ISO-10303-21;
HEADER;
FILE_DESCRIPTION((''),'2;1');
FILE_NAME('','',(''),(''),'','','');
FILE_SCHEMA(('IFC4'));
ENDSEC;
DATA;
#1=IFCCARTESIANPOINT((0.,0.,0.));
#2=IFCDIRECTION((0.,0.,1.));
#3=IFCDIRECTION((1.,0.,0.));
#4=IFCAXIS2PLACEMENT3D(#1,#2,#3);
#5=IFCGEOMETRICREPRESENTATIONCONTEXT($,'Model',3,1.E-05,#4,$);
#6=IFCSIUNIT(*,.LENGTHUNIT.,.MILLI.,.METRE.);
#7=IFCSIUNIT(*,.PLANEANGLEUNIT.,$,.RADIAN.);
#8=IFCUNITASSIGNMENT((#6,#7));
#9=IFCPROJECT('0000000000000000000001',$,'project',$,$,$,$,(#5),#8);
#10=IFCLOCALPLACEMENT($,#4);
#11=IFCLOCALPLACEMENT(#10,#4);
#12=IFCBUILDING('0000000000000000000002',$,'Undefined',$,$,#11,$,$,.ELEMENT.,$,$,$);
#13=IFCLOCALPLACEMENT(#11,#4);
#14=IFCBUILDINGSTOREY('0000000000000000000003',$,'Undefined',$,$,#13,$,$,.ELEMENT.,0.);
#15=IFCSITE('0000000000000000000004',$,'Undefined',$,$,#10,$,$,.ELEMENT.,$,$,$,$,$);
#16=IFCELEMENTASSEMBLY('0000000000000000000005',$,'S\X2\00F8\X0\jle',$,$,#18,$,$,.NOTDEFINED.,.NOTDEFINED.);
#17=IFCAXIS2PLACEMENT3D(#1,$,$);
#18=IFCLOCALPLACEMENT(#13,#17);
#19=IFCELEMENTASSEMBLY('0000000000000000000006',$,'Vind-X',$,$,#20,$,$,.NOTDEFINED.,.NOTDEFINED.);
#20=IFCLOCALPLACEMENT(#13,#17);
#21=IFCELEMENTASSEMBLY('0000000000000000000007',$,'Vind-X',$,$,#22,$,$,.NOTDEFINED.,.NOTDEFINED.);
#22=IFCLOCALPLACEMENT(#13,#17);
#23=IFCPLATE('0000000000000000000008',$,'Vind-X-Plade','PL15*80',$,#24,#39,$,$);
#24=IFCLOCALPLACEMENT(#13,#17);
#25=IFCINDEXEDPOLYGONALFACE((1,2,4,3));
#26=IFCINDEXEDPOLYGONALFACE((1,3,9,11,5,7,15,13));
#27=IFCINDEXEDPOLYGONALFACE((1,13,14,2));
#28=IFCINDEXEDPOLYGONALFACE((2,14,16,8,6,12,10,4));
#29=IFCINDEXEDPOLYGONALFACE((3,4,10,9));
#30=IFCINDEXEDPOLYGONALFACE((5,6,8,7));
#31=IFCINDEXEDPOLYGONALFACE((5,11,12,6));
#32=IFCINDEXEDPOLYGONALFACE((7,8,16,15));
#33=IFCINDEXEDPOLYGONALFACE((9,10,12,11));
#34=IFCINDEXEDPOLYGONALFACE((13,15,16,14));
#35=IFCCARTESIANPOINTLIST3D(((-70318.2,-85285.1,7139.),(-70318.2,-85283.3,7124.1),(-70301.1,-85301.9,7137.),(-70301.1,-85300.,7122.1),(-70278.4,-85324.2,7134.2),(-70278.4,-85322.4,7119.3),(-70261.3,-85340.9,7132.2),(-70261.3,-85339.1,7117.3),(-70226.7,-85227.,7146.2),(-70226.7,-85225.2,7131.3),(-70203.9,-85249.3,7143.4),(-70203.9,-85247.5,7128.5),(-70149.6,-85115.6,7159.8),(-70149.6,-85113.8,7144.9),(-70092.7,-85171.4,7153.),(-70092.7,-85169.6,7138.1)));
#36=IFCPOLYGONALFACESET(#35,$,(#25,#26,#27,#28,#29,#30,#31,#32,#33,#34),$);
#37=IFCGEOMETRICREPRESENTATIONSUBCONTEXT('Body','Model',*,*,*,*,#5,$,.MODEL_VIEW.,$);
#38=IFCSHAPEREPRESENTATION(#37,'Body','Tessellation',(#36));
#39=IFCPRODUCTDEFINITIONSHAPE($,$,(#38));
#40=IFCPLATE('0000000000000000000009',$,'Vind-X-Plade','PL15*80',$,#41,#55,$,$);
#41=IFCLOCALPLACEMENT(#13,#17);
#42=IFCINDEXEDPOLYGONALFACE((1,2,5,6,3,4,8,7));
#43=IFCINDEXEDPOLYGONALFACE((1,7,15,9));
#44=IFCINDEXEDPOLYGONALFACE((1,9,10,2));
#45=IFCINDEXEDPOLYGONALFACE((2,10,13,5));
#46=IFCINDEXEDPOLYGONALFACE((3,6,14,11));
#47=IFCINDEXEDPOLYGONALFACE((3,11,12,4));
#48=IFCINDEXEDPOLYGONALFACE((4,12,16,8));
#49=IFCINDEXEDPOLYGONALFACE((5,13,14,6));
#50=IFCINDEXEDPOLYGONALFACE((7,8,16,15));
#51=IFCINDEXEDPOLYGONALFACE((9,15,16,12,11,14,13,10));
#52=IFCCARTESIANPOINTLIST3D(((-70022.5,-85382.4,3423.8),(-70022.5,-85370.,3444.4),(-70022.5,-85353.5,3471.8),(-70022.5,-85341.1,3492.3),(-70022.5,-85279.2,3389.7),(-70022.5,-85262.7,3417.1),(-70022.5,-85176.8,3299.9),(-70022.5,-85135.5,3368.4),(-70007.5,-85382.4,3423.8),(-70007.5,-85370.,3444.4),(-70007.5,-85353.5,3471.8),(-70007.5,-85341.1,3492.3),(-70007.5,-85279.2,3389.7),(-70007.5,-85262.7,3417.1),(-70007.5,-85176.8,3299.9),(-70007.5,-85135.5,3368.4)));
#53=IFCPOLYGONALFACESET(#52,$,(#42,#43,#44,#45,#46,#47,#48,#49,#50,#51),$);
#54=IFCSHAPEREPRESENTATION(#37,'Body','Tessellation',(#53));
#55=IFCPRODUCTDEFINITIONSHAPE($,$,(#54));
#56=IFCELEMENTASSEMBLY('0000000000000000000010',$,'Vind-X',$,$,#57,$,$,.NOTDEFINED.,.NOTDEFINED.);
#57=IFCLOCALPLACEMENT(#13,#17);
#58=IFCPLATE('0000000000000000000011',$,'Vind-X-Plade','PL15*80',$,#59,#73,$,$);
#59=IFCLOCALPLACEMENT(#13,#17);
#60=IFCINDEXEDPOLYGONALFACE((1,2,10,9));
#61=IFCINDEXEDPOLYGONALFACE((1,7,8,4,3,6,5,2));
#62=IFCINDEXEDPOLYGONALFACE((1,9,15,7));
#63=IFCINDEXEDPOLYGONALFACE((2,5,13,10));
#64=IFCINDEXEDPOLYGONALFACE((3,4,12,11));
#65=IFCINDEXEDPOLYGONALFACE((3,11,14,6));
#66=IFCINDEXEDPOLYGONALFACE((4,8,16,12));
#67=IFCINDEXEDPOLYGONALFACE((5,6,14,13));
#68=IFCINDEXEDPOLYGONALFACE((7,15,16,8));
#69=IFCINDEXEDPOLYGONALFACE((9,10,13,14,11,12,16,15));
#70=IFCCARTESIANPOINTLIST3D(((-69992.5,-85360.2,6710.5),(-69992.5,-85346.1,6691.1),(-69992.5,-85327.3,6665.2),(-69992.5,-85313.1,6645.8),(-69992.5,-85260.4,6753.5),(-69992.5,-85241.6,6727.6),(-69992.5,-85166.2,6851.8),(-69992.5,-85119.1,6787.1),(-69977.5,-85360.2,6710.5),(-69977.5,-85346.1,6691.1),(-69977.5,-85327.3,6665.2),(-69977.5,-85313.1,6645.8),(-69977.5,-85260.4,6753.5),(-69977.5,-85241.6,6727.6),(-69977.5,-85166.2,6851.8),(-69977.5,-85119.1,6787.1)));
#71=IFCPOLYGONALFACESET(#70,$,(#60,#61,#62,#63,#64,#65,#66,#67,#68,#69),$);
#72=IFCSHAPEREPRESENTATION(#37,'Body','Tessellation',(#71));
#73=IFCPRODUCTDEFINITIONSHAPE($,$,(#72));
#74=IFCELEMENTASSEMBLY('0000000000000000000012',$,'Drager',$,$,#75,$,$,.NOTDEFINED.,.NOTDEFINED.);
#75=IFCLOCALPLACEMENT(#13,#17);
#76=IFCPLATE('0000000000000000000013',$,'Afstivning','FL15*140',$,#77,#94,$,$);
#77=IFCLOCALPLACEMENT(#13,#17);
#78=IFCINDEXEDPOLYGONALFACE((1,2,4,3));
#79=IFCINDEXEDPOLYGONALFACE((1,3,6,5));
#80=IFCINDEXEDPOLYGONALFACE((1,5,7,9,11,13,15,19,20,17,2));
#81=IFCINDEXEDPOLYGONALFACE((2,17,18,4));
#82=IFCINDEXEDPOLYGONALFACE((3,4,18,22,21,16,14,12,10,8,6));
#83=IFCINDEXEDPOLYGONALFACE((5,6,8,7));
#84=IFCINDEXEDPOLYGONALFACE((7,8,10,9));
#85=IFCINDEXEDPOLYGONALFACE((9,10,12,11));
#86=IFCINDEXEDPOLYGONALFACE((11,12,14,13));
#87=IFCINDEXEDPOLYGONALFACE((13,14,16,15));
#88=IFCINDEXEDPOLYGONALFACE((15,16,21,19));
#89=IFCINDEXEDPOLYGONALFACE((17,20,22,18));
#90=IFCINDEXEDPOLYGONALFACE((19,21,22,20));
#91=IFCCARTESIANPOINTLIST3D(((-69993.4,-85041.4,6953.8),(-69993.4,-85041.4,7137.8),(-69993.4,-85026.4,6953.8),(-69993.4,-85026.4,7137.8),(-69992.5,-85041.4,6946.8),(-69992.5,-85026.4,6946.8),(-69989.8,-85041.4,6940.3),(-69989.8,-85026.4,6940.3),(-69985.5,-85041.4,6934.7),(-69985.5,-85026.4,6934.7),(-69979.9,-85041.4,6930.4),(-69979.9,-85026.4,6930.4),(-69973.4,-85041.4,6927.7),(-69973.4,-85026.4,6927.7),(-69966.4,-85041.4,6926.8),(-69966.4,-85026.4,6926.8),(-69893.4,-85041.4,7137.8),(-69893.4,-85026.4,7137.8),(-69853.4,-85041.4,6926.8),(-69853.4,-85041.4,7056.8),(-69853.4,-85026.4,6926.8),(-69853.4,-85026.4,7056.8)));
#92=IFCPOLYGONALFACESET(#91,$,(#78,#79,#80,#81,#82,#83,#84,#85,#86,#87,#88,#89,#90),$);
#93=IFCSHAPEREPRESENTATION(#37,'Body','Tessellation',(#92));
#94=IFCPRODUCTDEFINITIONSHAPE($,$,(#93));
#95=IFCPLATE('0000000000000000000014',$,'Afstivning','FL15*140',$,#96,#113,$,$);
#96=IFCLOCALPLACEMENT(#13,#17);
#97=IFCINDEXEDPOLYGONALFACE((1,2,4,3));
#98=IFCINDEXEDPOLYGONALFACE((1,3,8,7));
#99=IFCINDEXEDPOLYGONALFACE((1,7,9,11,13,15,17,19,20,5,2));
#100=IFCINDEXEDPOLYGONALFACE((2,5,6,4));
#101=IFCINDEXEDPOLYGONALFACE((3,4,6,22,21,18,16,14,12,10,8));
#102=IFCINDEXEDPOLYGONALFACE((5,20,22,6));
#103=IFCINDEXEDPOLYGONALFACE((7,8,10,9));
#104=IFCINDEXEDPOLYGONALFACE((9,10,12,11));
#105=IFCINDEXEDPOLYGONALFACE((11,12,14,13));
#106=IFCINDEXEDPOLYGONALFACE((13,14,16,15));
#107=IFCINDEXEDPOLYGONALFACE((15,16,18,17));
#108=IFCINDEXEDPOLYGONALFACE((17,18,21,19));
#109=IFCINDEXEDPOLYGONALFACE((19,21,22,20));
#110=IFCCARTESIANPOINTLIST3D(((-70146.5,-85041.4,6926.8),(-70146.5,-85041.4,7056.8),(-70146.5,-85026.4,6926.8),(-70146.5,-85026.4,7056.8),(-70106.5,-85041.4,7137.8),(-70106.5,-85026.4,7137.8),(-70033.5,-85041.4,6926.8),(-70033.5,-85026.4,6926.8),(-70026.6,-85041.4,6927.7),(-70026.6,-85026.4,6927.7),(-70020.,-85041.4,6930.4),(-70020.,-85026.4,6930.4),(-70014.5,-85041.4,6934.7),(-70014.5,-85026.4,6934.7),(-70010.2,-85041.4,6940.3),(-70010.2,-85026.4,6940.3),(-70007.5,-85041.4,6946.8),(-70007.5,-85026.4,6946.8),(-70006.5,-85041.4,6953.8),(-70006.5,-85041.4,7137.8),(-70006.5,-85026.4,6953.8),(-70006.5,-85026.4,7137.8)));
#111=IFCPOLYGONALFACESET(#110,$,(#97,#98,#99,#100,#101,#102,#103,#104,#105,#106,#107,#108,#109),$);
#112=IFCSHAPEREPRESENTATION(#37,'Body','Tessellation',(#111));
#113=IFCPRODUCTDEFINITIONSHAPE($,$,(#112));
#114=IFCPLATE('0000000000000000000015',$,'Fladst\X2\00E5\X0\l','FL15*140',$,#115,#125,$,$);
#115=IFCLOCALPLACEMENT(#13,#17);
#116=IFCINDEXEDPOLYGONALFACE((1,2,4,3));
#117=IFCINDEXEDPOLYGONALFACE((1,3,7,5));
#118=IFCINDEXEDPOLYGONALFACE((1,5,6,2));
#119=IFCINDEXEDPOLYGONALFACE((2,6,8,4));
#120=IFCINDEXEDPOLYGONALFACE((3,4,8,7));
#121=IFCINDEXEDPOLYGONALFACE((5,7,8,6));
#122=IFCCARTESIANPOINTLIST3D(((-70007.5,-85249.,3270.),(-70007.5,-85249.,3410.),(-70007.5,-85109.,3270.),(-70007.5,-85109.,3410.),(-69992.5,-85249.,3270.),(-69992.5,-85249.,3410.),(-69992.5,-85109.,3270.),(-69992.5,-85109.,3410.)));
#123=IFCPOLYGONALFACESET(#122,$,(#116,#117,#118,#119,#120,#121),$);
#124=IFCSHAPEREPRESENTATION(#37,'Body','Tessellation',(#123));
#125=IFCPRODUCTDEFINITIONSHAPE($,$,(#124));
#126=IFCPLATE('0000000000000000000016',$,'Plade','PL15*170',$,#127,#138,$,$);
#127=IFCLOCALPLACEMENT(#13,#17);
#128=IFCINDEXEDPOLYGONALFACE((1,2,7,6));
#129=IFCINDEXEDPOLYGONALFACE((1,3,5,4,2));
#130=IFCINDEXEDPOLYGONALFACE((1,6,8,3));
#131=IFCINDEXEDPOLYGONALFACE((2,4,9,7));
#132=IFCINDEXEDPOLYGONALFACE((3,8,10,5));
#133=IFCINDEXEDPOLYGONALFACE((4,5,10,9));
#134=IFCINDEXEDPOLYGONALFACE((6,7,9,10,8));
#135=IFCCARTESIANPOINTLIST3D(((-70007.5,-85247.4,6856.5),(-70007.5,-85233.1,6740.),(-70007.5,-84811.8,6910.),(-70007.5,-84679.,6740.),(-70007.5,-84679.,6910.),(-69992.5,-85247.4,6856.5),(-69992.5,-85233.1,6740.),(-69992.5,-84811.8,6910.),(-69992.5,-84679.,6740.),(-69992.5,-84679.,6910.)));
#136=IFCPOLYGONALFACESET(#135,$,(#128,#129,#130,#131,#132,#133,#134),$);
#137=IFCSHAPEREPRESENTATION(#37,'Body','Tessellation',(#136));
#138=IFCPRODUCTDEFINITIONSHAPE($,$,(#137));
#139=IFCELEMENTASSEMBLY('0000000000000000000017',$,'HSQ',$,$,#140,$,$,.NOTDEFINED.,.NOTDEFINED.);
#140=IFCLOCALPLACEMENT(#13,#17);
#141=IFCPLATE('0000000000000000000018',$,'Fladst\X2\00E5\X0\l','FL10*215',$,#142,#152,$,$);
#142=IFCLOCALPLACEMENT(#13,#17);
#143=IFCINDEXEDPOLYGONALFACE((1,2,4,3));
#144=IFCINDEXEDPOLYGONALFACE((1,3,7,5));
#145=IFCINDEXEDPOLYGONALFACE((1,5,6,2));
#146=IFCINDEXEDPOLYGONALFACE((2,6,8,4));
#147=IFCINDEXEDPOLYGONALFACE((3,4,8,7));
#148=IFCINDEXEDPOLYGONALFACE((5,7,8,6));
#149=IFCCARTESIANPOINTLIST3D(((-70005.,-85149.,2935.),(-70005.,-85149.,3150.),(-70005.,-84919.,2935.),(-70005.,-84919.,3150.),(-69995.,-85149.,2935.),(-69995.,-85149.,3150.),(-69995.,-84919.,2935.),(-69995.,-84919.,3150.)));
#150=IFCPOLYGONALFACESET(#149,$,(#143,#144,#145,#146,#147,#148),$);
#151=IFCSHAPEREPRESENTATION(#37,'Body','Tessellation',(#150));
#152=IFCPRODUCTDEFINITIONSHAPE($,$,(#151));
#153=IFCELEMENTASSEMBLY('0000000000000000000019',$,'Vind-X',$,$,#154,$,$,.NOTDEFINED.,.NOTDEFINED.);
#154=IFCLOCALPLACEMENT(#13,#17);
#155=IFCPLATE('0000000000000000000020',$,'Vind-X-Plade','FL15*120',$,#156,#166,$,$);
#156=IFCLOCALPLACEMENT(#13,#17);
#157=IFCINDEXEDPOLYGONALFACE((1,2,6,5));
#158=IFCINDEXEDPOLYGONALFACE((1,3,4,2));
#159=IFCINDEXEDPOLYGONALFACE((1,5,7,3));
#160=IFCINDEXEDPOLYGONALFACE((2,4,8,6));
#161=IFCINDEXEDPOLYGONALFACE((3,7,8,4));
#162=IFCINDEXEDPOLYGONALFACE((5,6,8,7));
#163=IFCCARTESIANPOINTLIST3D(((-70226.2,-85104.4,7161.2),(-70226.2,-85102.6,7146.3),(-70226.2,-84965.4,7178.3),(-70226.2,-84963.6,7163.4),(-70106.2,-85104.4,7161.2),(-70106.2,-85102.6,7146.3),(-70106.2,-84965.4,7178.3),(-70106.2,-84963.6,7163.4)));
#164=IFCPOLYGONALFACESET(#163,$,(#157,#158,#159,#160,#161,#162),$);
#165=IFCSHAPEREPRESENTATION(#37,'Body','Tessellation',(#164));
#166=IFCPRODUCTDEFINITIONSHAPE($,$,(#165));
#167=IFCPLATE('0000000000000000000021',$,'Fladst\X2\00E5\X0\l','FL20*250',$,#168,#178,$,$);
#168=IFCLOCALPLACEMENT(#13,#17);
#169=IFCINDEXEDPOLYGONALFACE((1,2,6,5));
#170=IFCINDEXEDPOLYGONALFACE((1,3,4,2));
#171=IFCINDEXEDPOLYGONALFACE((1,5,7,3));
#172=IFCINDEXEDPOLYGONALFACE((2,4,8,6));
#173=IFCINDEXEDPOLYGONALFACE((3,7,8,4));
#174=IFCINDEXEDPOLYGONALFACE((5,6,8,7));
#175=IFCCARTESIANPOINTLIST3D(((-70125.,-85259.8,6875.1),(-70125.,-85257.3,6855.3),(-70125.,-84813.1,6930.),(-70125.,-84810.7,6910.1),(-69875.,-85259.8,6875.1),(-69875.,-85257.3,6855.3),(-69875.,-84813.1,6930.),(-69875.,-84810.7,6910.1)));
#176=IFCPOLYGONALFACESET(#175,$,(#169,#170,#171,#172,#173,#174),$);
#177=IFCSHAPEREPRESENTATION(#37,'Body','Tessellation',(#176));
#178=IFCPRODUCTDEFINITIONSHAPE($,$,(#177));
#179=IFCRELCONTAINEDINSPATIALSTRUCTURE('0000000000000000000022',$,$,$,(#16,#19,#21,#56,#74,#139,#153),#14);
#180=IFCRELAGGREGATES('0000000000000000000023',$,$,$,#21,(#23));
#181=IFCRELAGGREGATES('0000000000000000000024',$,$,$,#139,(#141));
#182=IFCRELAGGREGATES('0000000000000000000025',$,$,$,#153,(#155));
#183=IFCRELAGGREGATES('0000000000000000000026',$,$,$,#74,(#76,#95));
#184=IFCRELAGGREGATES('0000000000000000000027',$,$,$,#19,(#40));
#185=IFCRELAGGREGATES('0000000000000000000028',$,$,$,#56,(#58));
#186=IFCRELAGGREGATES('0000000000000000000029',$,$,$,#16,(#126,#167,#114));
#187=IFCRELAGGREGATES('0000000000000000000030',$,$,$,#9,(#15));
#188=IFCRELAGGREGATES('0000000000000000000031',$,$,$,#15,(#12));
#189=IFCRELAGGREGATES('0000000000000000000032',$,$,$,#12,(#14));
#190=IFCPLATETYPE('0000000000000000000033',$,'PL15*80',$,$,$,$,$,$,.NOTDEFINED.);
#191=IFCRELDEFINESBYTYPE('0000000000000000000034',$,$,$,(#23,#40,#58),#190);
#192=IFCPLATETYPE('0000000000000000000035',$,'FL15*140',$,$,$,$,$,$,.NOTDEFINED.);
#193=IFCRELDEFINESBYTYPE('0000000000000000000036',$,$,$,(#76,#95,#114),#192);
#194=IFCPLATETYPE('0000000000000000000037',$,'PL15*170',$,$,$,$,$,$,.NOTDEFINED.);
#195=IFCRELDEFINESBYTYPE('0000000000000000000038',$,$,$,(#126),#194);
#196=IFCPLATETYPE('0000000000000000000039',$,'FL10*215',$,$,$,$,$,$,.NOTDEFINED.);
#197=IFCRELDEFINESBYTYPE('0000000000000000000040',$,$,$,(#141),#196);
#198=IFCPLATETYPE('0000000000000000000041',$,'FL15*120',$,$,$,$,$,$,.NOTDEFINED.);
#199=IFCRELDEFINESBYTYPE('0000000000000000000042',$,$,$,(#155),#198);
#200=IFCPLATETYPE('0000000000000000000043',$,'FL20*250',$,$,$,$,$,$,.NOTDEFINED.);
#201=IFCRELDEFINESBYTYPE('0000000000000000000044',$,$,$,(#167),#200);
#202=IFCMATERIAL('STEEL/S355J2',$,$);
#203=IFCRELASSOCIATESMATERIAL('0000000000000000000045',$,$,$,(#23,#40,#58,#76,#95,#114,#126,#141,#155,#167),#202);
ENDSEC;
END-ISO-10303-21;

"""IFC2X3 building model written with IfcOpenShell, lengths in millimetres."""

from ifc_helpers import new_model, si_unit, frame, frame_2d, origin_with_axes, place, context, subcontext, project, spatial, polyline, circle_curve, parameter, trimmed, segment, composite_curve, outline, extrude, boolean, material, type_object, element, aggregate, save


model = new_model("IFC2X3")

# Units and contexts
model_context = context("Model", 3, precision=1e-05, world=origin_with_axes())
body_context = subcontext(model_context, "Body", "Model", "MODEL_VIEW")
ifc_project = project(units=[si_unit("LENGTHUNIT", "METRE", prefix="MILLI"), si_unit("PLANEANGLEUNIT", "RADIAN")], contexts=[model_context])

# Site, building, storey
site_placement = place(None, origin_with_axes())
site = spatial("IfcSite", under=ifc_project, at=site_placement, Name="Undefined", CompositionType="ELEMENT")
building_placement = place(site_placement, origin_with_axes())
building = spatial("IfcBuilding", under=site, at=building_placement, Name="Undefined", CompositionType="ELEMENT")
storey_placement = place(building_placement, origin_with_axes())
storey = spatial("IfcBuildingStorey", under=building, at=storey_placement, Name="Undefined", CompositionType="ELEMENT", Elevation=0.0)

# Element assembly
assembly_1_placement = place(storey_placement, origin_with_axes())
assembly_1 = element("IfcElementAssembly", 1, at=assembly_1_placement, inside=storey, Name="Søjle", AssemblyPlace="NOTDEFINED", PredefinedType="NOTDEFINED")

# Element assembly
assembly_2_placement = place(storey_placement, origin_with_axes())
assembly_2 = element("IfcElementAssembly", 2, at=assembly_2_placement, inside=storey, Name="Vind-X", AssemblyPlace="NOTDEFINED", PredefinedType="NOTDEFINED")
ifc_material_1 = material(Name="STEEL/S355J2")

# Element assembly, plate
assembly_3_placement = place(storey_placement, origin_with_axes())
assembly_3 = element("IfcElementAssembly", 3, at=assembly_3_placement, inside=storey, Name="Vind-X", AssemblyPlace="NOTDEFINED", PredefinedType="NOTDEFINED")
plate_type_1 = type_object("IfcPlateType", Name="PL15*80", PredefinedType="NOTDEFINED")
plate_1_placement = place(assembly_3_placement, frame((-70092.7, -85170.5, 7145.5), z_axis=(0.0, -0.121869, 0.992546), x_axis=(-0.711592, 0.697356, 0.085625)))
plate_1 = element("IfcPlate", 4, at=plate_1_placement, type_object=plate_type_1, material=ifc_material_1, Name="Vind-X-Plade", Description="PL15*80", context=body_context, shape_type="CSG", body=[
    boolean("DIFFERENCE", extrude(outline(polyline([(0.0, 0.0), (80.0, 0.0), (80.0, 240.0), (0.0, 240.0), (0.0, 0.0)])), frame((0.0, 0.0, -7.5), z_axis=(0.0, 0.0, 1.0), x_axis=(1.0, 0.0, 0.0)), (0.0, 0.0, 1.0), 15.0), extrude(outline(polyline([(0.0, 0.0), (106.0, 0.0), (106.0, 32.0), (0.0, 32.0), (0.0, 0.0)])), frame((56.0, 240.0, 8.5), z_axis=(0.0, 0.0, -1.0), x_axis=(0.0, -1.0, 0.0)), (0.0, 0.0, 1.0), 17.0)),
])
aggregate(assembly_3, [plate_1])

# Plate
plate_2_placement = place(assembly_2_placement, frame((-70015.0, -85176.8, 3299.9), z_axis=(1.0, 0.0, 0.0), x_axis=(0.0, 0.516247, 0.85644)))
plate_2 = element("IfcPlate", 5, at=plate_2_placement, type_object=plate_type_1, material=ifc_material_1, Name="Vind-X-Plade", Description="PL15*80", context=body_context, shape_type="CSG", body=[
    boolean("DIFFERENCE", extrude(outline(polyline([(0.0, 0.0), (80.0, 0.0), (80.0, 240.0), (0.0, 240.0), (0.0, 0.0)])), frame((0.0, 0.0, -7.5), z_axis=(0.0, 0.0, 1.0), x_axis=(1.0, 0.0, 0.0)), (0.0, 0.0, 1.0), 15.0), extrude(outline(polyline([(0.0, 0.0), (106.0, 0.0), (106.0, 32.0), (0.0, 32.0), (0.0, 0.0)])), frame((56.0, 240.0, 8.5), z_axis=(0.0, 0.0, -1.0), x_axis=(0.0, -1.0, 0.0)), (0.0, 0.0, 1.0), 17.0)),
])

# Element assembly, plate
assembly_4_placement = place(storey_placement, origin_with_axes())
assembly_4 = element("IfcElementAssembly", 6, at=assembly_4_placement, inside=storey, Name="Vind-X", AssemblyPlace="NOTDEFINED", PredefinedType="NOTDEFINED")
plate_3_placement = place(assembly_4_placement, frame((-69985.0, -85119.1, 6787.1), z_axis=(1.0, 0.0, 0.0), x_axis=(0.0, -0.588616, 0.808413)))
plate_3 = element("IfcPlate", 7, at=plate_3_placement, type_object=plate_type_1, material=ifc_material_1, Name="Vind-X-Plade", Description="PL15*80", context=body_context, shape_type="CSG", body=[
    boolean("DIFFERENCE", extrude(outline(polyline([(0.0, 0.0), (80.0, 0.0), (80.0, 240.0), (0.0, 240.0), (0.0, 0.0)])), frame((0.0, 0.0, -7.5), z_axis=(0.0, 0.0, 1.0), x_axis=(1.0, 0.0, 0.0)), (0.0, 0.0, 1.0), 15.0), extrude(outline(polyline([(0.0, 0.0), (106.0, 0.0), (106.0, 32.0), (0.0, 32.0), (0.0, 0.0)])), frame((56.0, 240.0, 8.5), z_axis=(0.0, 0.0, -1.0), x_axis=(0.0, -1.0, 0.0)), (0.0, 0.0, 1.0), 17.0)),
])

# Element assembly, plates
assembly_5_placement = place(storey_placement, origin_with_axes())
assembly_5 = element("IfcElementAssembly", 8, at=assembly_5_placement, inside=storey, Name="Drager", AssemblyPlace="NOTDEFINED", PredefinedType="NOTDEFINED")
plate_type_2 = type_object("IfcPlateType", Name="FL15*140", PredefinedType="NOTDEFINED")
plate_4_placement = place(assembly_5_placement, frame((-69993.4, -85033.9, 6926.8), z_axis=(0.0, -1.0, 0.0), x_axis=(1.0, 0.0, 0.0)))
plate_4 = element("IfcPlate", 9, at=plate_4_placement, type_object=plate_type_2, material=ifc_material_1, Name="Afstivning", Description="FL15*140", context=body_context, shape_type="SweptSolid", body=[
    extrude(outline(composite_curve([segment(trimmed(circle_curve(frame_2d((27.0, 27.0), x_axis=(-1.0, 0.0)), 27.0), [parameter(0.0)], [parameter(1.570796)], True, "PARAMETER"), True, "CONTINUOUS"), segment(polyline([(27.0, 0.0), (140.0, 0.0), (140.0, 130.0), (100.0, 211.0), (0.0, 211.0), (0.0, 27.0)]), True, "CONTINUOUS")], self_intersect=True)), frame((0.0, 0.0, -7.5), z_axis=(0.0, 0.0, 1.0), x_axis=(1.0, 0.0, 0.0)), (0.0, 0.0, 1.0), 15.0),
])
plate_5_placement = place(assembly_5_placement, frame((-70146.5, -85033.9, 6926.8), z_axis=(0.0, -1.0, 0.0), x_axis=(1.0, 0.0, 0.0)))
plate_5 = element("IfcPlate", 10, at=plate_5_placement, type_object=plate_type_2, material=ifc_material_1, Name="Afstivning", Description="FL15*140", context=body_context, shape_type="SweptSolid", body=[
    extrude(outline(composite_curve([segment(polyline([(0.0, 0.0), (113.0, 0.0)]), True, "CONTINUOUS"), segment(trimmed(circle_curve(frame_2d((113.0, 27.0), x_axis=(0.0, -1.0)), 27.0), [parameter(0.0)], [parameter(1.570796)], True, "PARAMETER"), True, "CONTINUOUS"), segment(polyline([(140.0, 27.0), (140.0, 211.0), (40.0, 211.0), (0.0, 130.0), (0.0, 0.0)]), True, "CONTINUOUS")], self_intersect=True)), frame((0.0, 0.0, -7.5), z_axis=(0.0, 0.0, 1.0), x_axis=(1.0, 0.0, 0.0)), (0.0, 0.0, 1.0), 15.0),
])

# Plates
plate_6_placement = place(assembly_1_placement, frame((-70000.0, -85109.0, 3270.0), z_axis=(-1.0, -0.000008, 0.0), x_axis=(0.000008, -1.0, 0.0)))
plate_6 = element("IfcPlate", 11, at=plate_6_placement, type_object=plate_type_2, material=ifc_material_1, Name="Fladstål", Description="FL15*140", context=body_context, shape_type="SweptSolid", body=[
    extrude(outline(polyline([(0.0, 0.0), (140.0, 0.0), (140.0, 140.0), (0.0, 140.0), (0.0, 0.0)])), frame((0.0, 0.0, -7.5), z_axis=(0.0, 0.0, 1.0), x_axis=(1.0, 0.0, 0.0)), (0.0, 0.0, 1.0), 15.0),
])
plate_type_3 = type_object("IfcPlateType", Name="PL15*170", PredefinedType="NOTDEFINED")
plate_7_placement = place(assembly_1_placement, frame((-70000.0, -85247.4, 6856.5), z_axis=(1.0, 0.0, 0.0), x_axis=(0.0, 0.121869, -0.992546)))
plate_7 = element("IfcPlate", 12, at=plate_7_placement, type_object=plate_type_3, material=ifc_material_1, Name="Plade", Description="PL15*170", context=body_context, shape_type="SweptSolid", body=[
    extrude(outline(polyline([(0.0, 0.0), (117.4, 0.0), (184.9, 550.0), (16.2, 570.7), (0.0, 438.9), (0.0, 0.0)])), frame((0.0, 0.0, -7.5), z_axis=(0.0, 0.0, 1.0), x_axis=(1.0, 0.0, 0.0)), (0.0, 0.0, 1.0), 15.0),
])

# Element assemblies, plates
assembly_6_placement = place(storey_placement, origin_with_axes())
assembly_6 = element("IfcElementAssembly", 13, at=assembly_6_placement, inside=storey, Name="HSQ", AssemblyPlace="NOTDEFINED", PredefinedType="NOTDEFINED")
plate_type_4 = type_object("IfcPlateType", Name="FL10*215", PredefinedType="NOTDEFINED")
plate_8_placement = place(assembly_6_placement, frame((-70000.0, -85149.0, 3150.0), z_axis=(1.0, 0.0, 0.0), x_axis=(0.0, 0.0, -1.0)))
plate_8 = element("IfcPlate", 14, at=plate_8_placement, type_object=plate_type_4, material=ifc_material_1, Name="Fladstål", Description="FL10*215", context=body_context, shape_type="SweptSolid", body=[
    extrude(outline(polyline([(0.0, 0.0), (215.0, 0.0), (215.0, 230.0), (0.0, 230.0), (0.0, 0.0)])), frame((0.0, 0.0, -5.0), z_axis=(0.0, 0.0, 1.0), x_axis=(1.0, 0.0, 0.0)), (0.0, 0.0, 1.0), 10.0),
])
aggregate(assembly_6, [plate_8])
assembly_7_placement = place(storey_placement, origin_with_axes())
assembly_7 = element("IfcElementAssembly", 15, at=assembly_7_placement, inside=storey, Name="Vind-X", AssemblyPlace="NOTDEFINED", PredefinedType="NOTDEFINED")
plate_type_5 = type_object("IfcPlateType", Name="FL15*120", PredefinedType="NOTDEFINED")
plate_9_placement = place(assembly_7_placement, frame((-70106.2, -85034.0, 7162.3), z_axis=(0.0, 0.121869, -0.992546), x_axis=(-1.0, 0.0, 0.0)))
plate_9 = element("IfcPlate", 16, at=plate_9_placement, type_object=plate_type_5, material=ifc_material_1, Name="Vind-X-Plade", Description="FL15*120", context=body_context, shape_type="SweptSolid", body=[
    extrude(outline(polyline([(0.0, -70.0), (0.0, 70.0), (120.0, 70.0), (120.0, -70.0), (0.0, -70.0)])), frame((0.0, 0.0, -7.5), z_axis=(0.0, 0.0, 1.0), x_axis=(1.0, 0.0, 0.0)), (0.0, 0.0, 1.0), 15.0),
])
aggregate(assembly_7, [plate_9])

# Plate
plate_type_6 = type_object("IfcPlateType", Name="FL20*250", PredefinedType="NOTDEFINED")
plate_10_placement = place(assembly_1_placement, frame((-70000.0, -85258.5, 6865.2), z_axis=(0.0, 0.121869, -0.992546), x_axis=(0.0, 0.992546, 0.121869)))
plate_10 = element("IfcPlate", 17, at=plate_10_placement, type_object=plate_type_6, material=ifc_material_1, Name="Fladstål", Description="FL20*250", context=body_context, shape_type="SweptSolid", body=[
    extrude(outline(polyline([(0.0, -125.0), (0.0, 125.0), (450.0, 125.0), (450.0, -125.0), (0.0, -125.0)])), frame((0.0, 0.0, -10.0), z_axis=(0.0, 0.0, 1.0), x_axis=(1.0, 0.0, 0.0)), (0.0, 0.0, 1.0), 20.0),
])
aggregate(assembly_5, [plate_4, plate_5])

aggregate(assembly_2, [plate_2])
aggregate(assembly_4, [plate_3])

aggregate(assembly_1, [plate_7, plate_10, plate_6])

save(model, "model.ifc")
